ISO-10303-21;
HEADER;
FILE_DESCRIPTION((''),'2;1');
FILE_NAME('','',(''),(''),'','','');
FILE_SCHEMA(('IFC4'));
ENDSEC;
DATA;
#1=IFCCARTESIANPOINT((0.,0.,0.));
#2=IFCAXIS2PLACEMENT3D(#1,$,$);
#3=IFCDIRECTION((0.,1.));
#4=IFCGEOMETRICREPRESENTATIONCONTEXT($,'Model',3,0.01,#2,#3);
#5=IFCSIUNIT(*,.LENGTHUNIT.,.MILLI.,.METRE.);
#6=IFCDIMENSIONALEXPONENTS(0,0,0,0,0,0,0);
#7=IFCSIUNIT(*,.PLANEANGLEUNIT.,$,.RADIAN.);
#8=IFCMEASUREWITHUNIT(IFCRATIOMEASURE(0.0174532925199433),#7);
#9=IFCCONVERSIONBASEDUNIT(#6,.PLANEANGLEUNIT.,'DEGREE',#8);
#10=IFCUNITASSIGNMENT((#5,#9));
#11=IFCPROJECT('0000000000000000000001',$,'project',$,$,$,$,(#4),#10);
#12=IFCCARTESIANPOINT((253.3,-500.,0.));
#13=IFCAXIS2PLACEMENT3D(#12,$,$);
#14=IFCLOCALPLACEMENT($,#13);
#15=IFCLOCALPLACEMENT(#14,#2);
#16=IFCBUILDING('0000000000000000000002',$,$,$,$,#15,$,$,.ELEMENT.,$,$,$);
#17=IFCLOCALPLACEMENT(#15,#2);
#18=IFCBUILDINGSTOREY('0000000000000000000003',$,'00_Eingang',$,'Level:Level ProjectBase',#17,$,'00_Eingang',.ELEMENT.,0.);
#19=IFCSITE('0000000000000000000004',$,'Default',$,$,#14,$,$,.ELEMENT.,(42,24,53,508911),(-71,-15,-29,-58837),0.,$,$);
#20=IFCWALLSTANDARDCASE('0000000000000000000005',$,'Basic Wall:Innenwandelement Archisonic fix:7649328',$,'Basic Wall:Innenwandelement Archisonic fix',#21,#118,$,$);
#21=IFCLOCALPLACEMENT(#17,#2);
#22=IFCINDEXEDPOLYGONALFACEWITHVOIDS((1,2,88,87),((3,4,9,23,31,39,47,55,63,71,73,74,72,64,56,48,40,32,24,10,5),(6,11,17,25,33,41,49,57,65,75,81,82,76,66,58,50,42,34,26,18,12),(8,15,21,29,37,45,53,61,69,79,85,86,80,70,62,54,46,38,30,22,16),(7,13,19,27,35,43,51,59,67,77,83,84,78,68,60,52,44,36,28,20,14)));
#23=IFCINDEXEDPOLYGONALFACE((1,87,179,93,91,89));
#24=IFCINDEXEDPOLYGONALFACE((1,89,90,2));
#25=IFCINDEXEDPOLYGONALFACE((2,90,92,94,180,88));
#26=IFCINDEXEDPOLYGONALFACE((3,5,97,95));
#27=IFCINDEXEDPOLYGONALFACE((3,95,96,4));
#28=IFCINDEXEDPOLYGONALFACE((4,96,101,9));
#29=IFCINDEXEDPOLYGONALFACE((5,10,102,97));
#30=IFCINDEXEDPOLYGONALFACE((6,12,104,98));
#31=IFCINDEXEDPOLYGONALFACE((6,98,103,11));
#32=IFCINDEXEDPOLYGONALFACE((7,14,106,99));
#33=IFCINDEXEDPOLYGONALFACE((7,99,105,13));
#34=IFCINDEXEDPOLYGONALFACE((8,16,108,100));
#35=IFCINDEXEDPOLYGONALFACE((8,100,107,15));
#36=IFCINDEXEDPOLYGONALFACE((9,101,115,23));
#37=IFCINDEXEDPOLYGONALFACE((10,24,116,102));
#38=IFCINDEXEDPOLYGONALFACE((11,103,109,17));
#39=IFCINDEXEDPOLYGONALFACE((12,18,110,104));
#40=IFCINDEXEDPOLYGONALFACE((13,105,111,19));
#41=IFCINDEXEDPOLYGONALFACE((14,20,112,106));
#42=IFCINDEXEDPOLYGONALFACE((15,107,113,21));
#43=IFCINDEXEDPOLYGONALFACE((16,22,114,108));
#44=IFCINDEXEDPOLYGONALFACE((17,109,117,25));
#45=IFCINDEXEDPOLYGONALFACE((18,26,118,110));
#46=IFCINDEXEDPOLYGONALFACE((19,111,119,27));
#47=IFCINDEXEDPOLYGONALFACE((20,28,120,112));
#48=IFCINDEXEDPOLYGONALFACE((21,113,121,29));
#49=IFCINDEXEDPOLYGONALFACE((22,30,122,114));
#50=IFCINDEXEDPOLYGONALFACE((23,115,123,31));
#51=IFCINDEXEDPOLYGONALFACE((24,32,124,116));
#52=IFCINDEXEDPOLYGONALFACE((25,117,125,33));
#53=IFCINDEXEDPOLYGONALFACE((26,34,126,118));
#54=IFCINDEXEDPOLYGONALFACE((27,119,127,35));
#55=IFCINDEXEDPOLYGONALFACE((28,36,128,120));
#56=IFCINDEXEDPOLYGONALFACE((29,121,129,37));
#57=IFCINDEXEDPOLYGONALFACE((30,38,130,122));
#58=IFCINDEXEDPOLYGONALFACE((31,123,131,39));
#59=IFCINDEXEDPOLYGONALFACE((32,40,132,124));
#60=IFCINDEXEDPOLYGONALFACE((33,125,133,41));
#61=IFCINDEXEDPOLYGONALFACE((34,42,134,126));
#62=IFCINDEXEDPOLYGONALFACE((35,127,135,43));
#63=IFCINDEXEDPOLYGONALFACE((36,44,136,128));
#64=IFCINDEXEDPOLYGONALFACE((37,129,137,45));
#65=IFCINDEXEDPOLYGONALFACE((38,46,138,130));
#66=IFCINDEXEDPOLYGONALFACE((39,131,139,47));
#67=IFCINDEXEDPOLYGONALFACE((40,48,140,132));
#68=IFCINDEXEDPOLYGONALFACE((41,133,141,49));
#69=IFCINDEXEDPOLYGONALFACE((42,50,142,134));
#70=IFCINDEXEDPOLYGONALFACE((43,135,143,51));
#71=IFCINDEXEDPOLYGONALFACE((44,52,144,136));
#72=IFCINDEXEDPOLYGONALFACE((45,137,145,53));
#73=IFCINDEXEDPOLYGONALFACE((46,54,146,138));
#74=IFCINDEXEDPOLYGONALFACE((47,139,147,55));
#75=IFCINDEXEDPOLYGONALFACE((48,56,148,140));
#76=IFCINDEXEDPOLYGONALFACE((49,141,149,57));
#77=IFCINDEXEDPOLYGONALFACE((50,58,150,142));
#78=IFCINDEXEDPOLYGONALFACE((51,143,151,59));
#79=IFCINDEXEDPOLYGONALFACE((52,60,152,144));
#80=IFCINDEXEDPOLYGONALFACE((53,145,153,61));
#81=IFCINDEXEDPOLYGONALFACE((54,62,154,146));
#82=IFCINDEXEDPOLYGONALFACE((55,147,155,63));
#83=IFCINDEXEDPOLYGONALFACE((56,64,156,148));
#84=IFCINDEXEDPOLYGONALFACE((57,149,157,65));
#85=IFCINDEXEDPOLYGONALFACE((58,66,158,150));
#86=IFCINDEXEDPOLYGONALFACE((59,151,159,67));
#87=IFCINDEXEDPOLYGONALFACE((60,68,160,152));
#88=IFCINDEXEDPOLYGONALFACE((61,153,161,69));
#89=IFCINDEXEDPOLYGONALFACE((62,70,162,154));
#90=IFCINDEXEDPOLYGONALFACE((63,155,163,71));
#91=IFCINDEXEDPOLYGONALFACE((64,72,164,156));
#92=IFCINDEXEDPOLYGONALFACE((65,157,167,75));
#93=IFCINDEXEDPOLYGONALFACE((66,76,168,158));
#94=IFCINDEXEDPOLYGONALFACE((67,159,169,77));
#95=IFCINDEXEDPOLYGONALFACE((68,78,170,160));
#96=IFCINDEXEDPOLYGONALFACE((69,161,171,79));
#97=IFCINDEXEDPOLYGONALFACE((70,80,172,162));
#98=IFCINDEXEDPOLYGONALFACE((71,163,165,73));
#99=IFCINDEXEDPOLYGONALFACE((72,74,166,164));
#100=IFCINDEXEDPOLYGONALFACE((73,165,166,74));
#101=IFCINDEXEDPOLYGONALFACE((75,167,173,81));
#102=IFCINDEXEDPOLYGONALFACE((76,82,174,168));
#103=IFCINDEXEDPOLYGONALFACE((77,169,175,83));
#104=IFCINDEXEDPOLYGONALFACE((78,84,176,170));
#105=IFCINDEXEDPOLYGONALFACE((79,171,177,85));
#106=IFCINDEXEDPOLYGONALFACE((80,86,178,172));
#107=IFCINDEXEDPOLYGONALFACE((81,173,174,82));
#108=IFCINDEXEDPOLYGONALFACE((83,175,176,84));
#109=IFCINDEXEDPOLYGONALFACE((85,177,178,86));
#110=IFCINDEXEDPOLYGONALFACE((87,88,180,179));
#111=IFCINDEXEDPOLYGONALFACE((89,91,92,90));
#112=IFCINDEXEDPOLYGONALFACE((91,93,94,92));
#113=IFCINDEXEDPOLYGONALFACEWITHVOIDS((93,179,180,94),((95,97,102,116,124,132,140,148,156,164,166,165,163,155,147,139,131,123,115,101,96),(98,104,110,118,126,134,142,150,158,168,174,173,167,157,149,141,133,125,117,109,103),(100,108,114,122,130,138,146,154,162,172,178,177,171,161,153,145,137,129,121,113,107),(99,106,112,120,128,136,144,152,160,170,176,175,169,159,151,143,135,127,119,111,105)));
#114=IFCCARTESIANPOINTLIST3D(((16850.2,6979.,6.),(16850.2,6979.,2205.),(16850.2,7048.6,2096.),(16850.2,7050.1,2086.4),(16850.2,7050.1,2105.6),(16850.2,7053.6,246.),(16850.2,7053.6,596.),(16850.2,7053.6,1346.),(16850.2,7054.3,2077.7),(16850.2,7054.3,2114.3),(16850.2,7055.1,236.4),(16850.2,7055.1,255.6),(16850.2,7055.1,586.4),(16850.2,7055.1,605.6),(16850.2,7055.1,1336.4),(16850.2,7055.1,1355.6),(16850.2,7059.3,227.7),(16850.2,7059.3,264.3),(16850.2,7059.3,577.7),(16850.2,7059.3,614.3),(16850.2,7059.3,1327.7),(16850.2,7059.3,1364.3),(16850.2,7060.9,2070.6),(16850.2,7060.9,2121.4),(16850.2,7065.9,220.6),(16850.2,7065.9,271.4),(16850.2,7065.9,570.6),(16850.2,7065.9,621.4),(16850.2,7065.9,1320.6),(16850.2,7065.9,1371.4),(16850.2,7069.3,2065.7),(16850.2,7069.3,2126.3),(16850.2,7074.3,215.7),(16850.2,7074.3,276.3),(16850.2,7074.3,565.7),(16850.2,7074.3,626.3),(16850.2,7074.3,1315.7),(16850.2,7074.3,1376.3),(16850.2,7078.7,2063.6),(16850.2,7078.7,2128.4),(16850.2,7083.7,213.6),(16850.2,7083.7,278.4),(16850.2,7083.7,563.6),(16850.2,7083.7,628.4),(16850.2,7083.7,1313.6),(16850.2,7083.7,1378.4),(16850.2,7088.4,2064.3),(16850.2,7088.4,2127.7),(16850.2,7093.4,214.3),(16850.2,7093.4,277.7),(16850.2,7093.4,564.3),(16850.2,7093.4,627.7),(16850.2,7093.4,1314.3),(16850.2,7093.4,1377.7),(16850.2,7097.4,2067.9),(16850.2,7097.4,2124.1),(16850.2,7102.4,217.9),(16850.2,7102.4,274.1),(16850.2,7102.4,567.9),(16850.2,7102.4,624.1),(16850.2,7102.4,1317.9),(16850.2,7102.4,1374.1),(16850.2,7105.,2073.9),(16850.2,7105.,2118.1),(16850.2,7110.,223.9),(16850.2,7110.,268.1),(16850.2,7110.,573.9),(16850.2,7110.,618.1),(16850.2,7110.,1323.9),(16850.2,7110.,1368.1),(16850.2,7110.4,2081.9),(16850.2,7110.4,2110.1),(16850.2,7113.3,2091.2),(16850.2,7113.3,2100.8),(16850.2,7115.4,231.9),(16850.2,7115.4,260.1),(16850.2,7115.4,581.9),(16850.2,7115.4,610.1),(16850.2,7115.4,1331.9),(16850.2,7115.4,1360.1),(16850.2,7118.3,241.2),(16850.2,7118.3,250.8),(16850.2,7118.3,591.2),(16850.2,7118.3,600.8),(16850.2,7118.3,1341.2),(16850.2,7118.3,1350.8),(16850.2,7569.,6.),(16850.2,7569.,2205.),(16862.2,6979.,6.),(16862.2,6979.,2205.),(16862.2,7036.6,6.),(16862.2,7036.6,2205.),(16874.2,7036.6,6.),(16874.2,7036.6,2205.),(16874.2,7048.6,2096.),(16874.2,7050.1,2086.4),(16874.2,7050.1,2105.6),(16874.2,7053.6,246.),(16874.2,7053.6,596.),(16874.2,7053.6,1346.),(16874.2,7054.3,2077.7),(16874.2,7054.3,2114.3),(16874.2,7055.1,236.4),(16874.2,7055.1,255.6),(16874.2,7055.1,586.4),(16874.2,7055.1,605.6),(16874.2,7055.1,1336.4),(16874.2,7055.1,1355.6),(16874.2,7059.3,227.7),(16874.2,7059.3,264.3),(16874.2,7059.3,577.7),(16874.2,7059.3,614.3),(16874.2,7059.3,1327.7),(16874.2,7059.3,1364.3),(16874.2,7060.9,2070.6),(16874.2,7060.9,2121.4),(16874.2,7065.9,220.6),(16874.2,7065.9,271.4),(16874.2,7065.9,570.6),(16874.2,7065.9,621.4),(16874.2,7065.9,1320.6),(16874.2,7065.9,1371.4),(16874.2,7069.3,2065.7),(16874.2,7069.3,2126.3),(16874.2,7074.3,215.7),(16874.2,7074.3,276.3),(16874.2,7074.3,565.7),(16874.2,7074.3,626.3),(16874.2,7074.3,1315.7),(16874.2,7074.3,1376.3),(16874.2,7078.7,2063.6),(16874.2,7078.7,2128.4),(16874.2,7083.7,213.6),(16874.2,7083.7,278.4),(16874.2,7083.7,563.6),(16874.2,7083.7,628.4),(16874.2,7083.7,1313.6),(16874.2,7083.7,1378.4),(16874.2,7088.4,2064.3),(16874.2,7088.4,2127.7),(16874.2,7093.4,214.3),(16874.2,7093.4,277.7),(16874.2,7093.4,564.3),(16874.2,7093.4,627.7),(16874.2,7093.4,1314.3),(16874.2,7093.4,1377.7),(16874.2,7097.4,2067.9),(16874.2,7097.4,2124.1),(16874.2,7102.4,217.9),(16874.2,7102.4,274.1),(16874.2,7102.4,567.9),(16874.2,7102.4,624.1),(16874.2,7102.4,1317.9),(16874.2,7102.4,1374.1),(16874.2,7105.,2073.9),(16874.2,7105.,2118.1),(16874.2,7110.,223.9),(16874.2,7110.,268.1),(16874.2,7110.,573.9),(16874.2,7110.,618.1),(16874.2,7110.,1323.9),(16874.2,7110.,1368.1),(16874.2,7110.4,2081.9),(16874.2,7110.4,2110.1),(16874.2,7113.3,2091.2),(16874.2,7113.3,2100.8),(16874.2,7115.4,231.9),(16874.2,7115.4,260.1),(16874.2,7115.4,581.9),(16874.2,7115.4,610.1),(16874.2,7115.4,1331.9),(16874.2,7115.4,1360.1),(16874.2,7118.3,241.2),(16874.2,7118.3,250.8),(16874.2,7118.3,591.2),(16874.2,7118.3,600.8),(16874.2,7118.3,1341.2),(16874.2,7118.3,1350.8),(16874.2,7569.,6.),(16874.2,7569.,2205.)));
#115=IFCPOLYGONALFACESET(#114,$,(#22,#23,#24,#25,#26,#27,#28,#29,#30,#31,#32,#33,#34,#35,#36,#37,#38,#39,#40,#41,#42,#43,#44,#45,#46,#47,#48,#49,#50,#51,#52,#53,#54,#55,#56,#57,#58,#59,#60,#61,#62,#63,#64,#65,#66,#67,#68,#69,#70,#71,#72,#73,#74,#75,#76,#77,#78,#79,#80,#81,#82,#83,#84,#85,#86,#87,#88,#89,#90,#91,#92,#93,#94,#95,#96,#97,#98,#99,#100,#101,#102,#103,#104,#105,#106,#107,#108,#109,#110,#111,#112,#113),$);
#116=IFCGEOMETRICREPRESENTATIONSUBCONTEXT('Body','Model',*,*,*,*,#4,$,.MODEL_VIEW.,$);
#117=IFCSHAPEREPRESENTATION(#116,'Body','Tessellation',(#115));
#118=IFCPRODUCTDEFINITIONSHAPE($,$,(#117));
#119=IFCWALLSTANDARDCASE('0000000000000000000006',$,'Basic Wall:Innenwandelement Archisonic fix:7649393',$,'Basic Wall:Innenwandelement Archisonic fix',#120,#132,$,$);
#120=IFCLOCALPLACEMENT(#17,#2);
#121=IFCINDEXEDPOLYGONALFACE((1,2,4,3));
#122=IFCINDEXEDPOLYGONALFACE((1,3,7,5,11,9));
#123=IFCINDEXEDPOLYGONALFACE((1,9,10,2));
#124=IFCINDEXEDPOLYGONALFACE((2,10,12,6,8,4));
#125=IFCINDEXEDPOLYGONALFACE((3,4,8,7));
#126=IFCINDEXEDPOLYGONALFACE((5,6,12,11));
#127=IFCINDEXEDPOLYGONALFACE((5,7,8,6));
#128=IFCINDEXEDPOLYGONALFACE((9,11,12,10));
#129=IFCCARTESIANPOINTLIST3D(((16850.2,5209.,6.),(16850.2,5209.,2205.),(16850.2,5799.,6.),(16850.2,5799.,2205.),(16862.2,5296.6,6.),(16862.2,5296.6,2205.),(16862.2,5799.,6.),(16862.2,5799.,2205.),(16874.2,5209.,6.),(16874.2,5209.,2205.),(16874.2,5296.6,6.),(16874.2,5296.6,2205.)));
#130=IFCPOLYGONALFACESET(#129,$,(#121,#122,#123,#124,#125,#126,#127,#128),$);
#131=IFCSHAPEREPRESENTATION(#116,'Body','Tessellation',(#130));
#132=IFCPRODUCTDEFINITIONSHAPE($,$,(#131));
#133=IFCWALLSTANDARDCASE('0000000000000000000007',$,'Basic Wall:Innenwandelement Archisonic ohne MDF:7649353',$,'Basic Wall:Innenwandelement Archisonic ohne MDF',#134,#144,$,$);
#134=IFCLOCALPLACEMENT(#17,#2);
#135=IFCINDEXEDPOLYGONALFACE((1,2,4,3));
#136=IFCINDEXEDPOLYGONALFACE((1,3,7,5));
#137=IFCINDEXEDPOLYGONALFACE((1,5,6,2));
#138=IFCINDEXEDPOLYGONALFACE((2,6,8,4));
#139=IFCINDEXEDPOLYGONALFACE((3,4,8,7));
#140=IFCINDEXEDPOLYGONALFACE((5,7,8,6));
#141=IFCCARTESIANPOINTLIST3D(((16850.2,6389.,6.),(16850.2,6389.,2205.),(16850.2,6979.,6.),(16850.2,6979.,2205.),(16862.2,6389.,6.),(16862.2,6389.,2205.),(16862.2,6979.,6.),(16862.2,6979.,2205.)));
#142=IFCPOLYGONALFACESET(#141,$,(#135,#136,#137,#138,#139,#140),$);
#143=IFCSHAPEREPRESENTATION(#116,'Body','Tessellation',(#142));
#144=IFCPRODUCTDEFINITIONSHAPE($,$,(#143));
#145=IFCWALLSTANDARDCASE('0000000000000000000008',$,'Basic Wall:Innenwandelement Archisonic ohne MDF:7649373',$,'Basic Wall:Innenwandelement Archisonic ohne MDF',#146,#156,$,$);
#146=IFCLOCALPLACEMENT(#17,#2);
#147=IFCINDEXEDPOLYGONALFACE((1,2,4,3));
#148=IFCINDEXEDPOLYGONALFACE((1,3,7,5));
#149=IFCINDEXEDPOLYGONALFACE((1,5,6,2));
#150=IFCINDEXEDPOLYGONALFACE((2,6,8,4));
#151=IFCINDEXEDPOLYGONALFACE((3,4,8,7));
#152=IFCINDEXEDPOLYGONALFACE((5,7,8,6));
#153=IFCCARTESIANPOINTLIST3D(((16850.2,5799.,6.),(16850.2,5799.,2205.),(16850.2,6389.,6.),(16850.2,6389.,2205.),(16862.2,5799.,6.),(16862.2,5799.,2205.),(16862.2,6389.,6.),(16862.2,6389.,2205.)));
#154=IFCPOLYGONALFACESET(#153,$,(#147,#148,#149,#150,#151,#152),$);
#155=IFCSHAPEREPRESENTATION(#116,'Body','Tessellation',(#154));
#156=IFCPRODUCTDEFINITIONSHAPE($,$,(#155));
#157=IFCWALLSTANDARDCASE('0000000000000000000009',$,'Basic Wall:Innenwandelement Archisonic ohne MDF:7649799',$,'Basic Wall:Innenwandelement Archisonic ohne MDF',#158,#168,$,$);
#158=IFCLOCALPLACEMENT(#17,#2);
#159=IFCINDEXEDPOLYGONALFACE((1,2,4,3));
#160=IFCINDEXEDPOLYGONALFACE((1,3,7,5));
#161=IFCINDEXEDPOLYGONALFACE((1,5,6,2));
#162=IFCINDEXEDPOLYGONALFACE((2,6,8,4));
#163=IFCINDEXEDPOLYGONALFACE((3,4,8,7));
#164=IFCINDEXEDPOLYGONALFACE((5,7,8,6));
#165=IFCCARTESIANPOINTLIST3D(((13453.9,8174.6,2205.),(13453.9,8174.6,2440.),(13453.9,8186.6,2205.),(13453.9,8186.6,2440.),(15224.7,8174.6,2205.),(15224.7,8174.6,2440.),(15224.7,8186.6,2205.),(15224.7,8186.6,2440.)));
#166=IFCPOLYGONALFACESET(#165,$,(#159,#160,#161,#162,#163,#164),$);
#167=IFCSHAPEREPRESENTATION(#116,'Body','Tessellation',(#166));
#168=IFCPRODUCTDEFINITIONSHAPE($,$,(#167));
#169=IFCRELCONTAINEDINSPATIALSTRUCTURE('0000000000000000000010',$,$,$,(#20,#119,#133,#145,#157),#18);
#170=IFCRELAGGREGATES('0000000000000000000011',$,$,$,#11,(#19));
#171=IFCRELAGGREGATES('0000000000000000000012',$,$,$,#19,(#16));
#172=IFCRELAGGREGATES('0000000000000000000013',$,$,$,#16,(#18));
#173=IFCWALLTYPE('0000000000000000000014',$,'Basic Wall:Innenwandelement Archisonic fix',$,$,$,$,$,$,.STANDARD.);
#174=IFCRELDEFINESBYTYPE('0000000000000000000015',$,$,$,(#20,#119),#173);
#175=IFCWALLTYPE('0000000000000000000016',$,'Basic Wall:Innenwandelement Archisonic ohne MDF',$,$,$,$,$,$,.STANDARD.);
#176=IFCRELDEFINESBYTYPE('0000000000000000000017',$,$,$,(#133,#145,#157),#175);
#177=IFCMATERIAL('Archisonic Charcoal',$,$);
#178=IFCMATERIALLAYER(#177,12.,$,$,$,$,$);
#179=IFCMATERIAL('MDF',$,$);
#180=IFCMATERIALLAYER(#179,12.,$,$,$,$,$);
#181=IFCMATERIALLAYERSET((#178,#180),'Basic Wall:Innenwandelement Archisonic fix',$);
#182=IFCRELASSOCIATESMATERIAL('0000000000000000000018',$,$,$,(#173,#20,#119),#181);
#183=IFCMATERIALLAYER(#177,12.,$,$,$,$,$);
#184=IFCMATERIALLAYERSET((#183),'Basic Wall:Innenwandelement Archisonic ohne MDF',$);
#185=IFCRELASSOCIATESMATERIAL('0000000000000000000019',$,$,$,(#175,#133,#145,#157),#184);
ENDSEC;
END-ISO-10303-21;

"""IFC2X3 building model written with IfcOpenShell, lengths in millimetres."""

from ifc_helpers import new_model, entity, si_unit, converted_unit, direction, frame, frame_2d, origin, origin_2d_with_axis, place, context, subcontext, project, spatial, polyline, rectangle, circle, extrude, clip, bounded_halfspace, material, layer, layer_set, layer_usage, type_object, element, save


model = new_model("IFC2X3")

# Units and contexts
model_context = context("Model", 3, precision=0.01, world=origin(), true_north=direction((0.0, 1.0)))
body_context = subcontext(model_context, "Body", "Model", "MODEL_VIEW")
ifc_project = project(units=[si_unit("LENGTHUNIT", "METRE", prefix="MILLI"), converted_unit("PLANEANGLEUNIT", "DEGREE", entity("IfcRatioMeasure", 0.0174532925199433), si_unit("PLANEANGLEUNIT", "RADIAN"), dimensions=[0, 0, 0, 0, 0, 0, 0])], contexts=[model_context])

# Site, building, storey
site_placement = place(None, frame((253.3, -500.0, 0.0)))
site = spatial("IfcSite", under=ifc_project, at=site_placement, Name="Default", CompositionType="ELEMENT", RefLatitude=(42, 24, 53, 508911), RefLongitude=(-71, -15, -29, -58837), RefElevation=0.0)
building_placement = place(site_placement, origin())
building = spatial("IfcBuilding", under=site, at=building_placement, CompositionType="ELEMENT")
storey_placement = place(building_placement, origin())
storey = spatial("IfcBuildingStorey", under=building, at=storey_placement, Name="00_Eingang", ObjectType="Level:Level ProjectBase", LongName="00_Eingang", CompositionType="ELEMENT", Elevation=0.0)

# Shared definitions
ifc_material_1 = material(Name="Archisonic Charcoal")
ifc_material_2 = material(Name="MDF")

# Shared definitions
ifc_layer_1 = layer(ifc_material_1, 12.0)
ifc_layer_2 = layer(ifc_material_2, 12.0)
ifc_layer_set_1 = layer_set([ifc_layer_1, ifc_layer_2], Name="Basic Wall:Innenwandelement Archisonic fix")
wall_type_1 = type_object("IfcWallType", Name="Basic Wall:Innenwandelement Archisonic fix", PredefinedType="STANDARD", material=ifc_layer_set_1)

# Wall, openings
ifc_layer_usage_1 = layer_usage(ifc_layer_set_1, "AXIS2", "NEGATIVE", 12.0)
wall_1_placement = place(storey_placement, frame((16862.2, 6979.0, 6.0), z_axis=(0.0, 0.0, 1.0), x_axis=(0.0, 1.0, 0.0)))
wall_1 = element("IfcWallStandardCase", 1, at=wall_1_placement, inside=storey, type_object=wall_type_1, material=ifc_layer_usage_1, Name="Basic Wall:Innenwandelement Archisonic fix:7649328", ObjectType="Basic Wall:Innenwandelement Archisonic fix", context=body_context, shape_type="Clipping", body=[
    clip(clip(extrude(rectangle(XDim=590.0, YDim=24.0, at=frame_2d((295.0, 0.0), x_axis=(-1.0, 0.0))), origin(), (0.0, 0.0, 1.0), 2199.0), bounded_halfspace(frame((57.6, 0.0, 0.0), z_axis=(0.0, 1.0, 0.0), x_axis=(-1.0, 0.0, 0.0)), True, frame((57.6, 0.0, 0.0), z_axis=(0.0, 1.0, 0.0), x_axis=(-1.0, 0.0, 0.0)), polyline([(0.0, 0.0), (57.6, 0.0), (57.6, 2199.0), (0.0, 2199.0), (0.0, 0.0)]))), bounded_halfspace(frame((57.6, 0.0, 2199.0), z_axis=(1.0, 0.0, 0.0), x_axis=(0.0, -1.0, 0.0)), True, frame((57.6, 0.0, 2199.0), z_axis=(1.0, 0.0, 0.0), x_axis=(0.0, -1.0, 0.0)), polyline([(0.0, 0.0), (12.0, 0.0), (12.0, 2199.0), (0.0, 2199.0), (0.0, 0.0)]))),
])
opening_1_placement = place(wall_1_placement, frame((68.0, 12.4, 2055.9)))
element("IfcOpeningElement", 2, at=opening_1_placement, cuts=wall_1, ObjectType="Opening", context=body_context, shape_type="SweptSolid", body=[
    extrude(circle(Radius=32.5, at=origin_2d_with_axis()), frame((34.1, -59.0, 34.1), z_axis=(0.0, 1.0, 0.0), x_axis=(-1.0, 0.0, 0.0)), (0.0, 0.0, 1.0), 59.0),
])
opening_2_placement = place(wall_1_placement, frame((73.0, 12.4, 205.9)))
element("IfcOpeningElement", 3, at=opening_2_placement, cuts=wall_1, ObjectType="Opening", context=body_context, shape_type="SweptSolid", body=[
    extrude(circle(Radius=32.5, at=frame_2d((0.0, 0.0), x_axis=(1.0, 0.0))), frame((34.1, -59.0, 34.1), z_axis=(0.0, 1.0, 0.0), x_axis=(-1.0, 0.0, 0.0)), (0.0, 0.0, 1.0), 59.0),
])
opening_3_placement = place(wall_1_placement, frame((73.0, 12.4, 1305.9)))
element("IfcOpeningElement", 4, at=opening_3_placement, cuts=wall_1, ObjectType="Opening", context=body_context, shape_type="SweptSolid", body=[
    extrude(circle(Radius=32.5, at=origin_2d_with_axis()), frame((34.1, -59.0, 34.1), z_axis=(0.0, 1.0, 0.0), x_axis=(-1.0, 0.0, 0.0)), (0.0, 0.0, 1.0), 59.0),
])
opening_4_placement = place(wall_1_placement, frame((73.0, 12.4, 555.9)))
element("IfcOpeningElement", 5, at=opening_4_placement, cuts=wall_1, ObjectType="Opening", context=body_context, shape_type="SweptSolid", body=[
    extrude(circle(Radius=32.5, at=frame_2d((0.0, 0.0), x_axis=(1.0, 0.0))), frame((34.1, -59.0, 34.1), z_axis=(0.0, 1.0, 0.0), x_axis=(-1.0, 0.0, 0.0)), (0.0, 0.0, 1.0), 59.0),
])

# Walls
ifc_layer_usage_2 = layer_usage(ifc_layer_set_1, "AXIS2", "POSITIVE", -12.0)
wall_2_placement = place(storey_placement, frame((16862.2, 5799.0, 6.0), z_axis=(0.0, 0.0, 1.0), x_axis=(0.0, -1.0, 0.0)))
element("IfcWallStandardCase", 6, at=wall_2_placement, inside=storey, type_object=wall_type_1, material=ifc_layer_usage_2, Name="Basic Wall:Innenwandelement Archisonic fix:7649393", ObjectType="Basic Wall:Innenwandelement Archisonic fix", context=body_context, shape_type="Clipping", body=[
    clip(clip(extrude(rectangle(XDim=590.0, YDim=24.0, at=frame_2d((295.0, 0.0), x_axis=(-1.0, 0.0))), origin(), (0.0, 0.0, 1.0), 2199.0), bounded_halfspace(frame((502.4, 0.0, 2199.0), z_axis=(0.0, -1.0, 0.0), x_axis=(1.0, 0.0, 0.0)), True, frame((502.4, 0.0, 2199.0), z_axis=(0.0, -1.0, 0.0), x_axis=(1.0, 0.0, 0.0)), polyline([(0.0, 0.0), (-502.4, 0.0), (-502.4, -2199.0), (0.0, -2199.0), (0.0, 0.0)]))), bounded_halfspace(frame((502.4, 0.0, 0.0), z_axis=(1.0, 0.0, 0.0), x_axis=(0.0, 1.0, 0.0)), True, frame((502.4, 0.0, 0.0), z_axis=(1.0, 0.0, 0.0), x_axis=(0.0, 1.0, 0.0)), polyline([(0.0, 0.0), (12.0, 0.0), (12.0, 2199.0), (0.0, 2199.0), (0.0, 0.0)]))),
])
ifc_layer_3 = layer(ifc_material_1, 12.0)
ifc_layer_set_2 = layer_set([ifc_layer_3], Name="Basic Wall:Innenwandelement Archisonic ohne MDF")
ifc_layer_usage_3 = layer_usage(ifc_layer_set_2, "AXIS2", "POSITIVE", -6.0)
wall_type_2 = type_object("IfcWallType", Name="Basic Wall:Innenwandelement Archisonic ohne MDF", PredefinedType="STANDARD", material=ifc_layer_set_2)
wall_3_placement = place(storey_placement, frame((16856.2, 6979.0, 6.0), z_axis=(0.0, 0.0, 1.0), x_axis=(0.0, -1.0, 0.0)))
element("IfcWallStandardCase", 7, at=wall_3_placement, inside=storey, type_object=wall_type_2, material=ifc_layer_usage_3, Name="Basic Wall:Innenwandelement Archisonic ohne MDF:7649353", ObjectType="Basic Wall:Innenwandelement Archisonic ohne MDF", context=body_context, shape_type="SweptSolid", body=[
    extrude(rectangle(XDim=590.0, YDim=12.0, at=frame_2d((295.0, 0.0), x_axis=(-1.0, 0.0))), origin(), (0.0, 0.0, 1.0), 2199.0),
])
ifc_layer_usage_4 = layer_usage(ifc_layer_set_2, "AXIS2", "NEGATIVE", 6.0)
wall_4_placement = place(storey_placement, frame((16856.2, 5799.0, 6.0), z_axis=(0.0, 0.0, 1.0), x_axis=(0.0, 1.0, 0.0)))
element("IfcWallStandardCase", 8, at=wall_4_placement, inside=storey, type_object=wall_type_2, material=ifc_layer_usage_4, Name="Basic Wall:Innenwandelement Archisonic ohne MDF:7649373", ObjectType="Basic Wall:Innenwandelement Archisonic ohne MDF", context=body_context, shape_type="SweptSolid", body=[
    extrude(rectangle(XDim=590.0, YDim=12.0, at=frame_2d((295.0, 0.0), x_axis=(-1.0, 0.0))), origin(), (0.0, 0.0, 1.0), 2199.0),
])
ifc_layer_usage_5 = layer_usage(ifc_layer_set_2, "AXIS2", "NEGATIVE", 6.0)
wall_5_placement = place(storey_placement, frame((15224.7, 8180.6, 2205.0), z_axis=(0.0, 0.0, 1.0), x_axis=(-1.0, 0.0, 0.0)))
element("IfcWallStandardCase", 9, at=wall_5_placement, inside=storey, type_object=wall_type_2, material=ifc_layer_usage_5, Name="Basic Wall:Innenwandelement Archisonic ohne MDF:7649799", ObjectType="Basic Wall:Innenwandelement Archisonic ohne MDF", context=body_context, shape_type="SweptSolid", body=[
    extrude(rectangle(XDim=1770.8, YDim=12.0, at=frame_2d((885.4, 0.0), x_axis=(-1.0, 0.0))), origin(), (0.0, 0.0, 1.0), 235.0),
])

save(model, "model.ifc")
